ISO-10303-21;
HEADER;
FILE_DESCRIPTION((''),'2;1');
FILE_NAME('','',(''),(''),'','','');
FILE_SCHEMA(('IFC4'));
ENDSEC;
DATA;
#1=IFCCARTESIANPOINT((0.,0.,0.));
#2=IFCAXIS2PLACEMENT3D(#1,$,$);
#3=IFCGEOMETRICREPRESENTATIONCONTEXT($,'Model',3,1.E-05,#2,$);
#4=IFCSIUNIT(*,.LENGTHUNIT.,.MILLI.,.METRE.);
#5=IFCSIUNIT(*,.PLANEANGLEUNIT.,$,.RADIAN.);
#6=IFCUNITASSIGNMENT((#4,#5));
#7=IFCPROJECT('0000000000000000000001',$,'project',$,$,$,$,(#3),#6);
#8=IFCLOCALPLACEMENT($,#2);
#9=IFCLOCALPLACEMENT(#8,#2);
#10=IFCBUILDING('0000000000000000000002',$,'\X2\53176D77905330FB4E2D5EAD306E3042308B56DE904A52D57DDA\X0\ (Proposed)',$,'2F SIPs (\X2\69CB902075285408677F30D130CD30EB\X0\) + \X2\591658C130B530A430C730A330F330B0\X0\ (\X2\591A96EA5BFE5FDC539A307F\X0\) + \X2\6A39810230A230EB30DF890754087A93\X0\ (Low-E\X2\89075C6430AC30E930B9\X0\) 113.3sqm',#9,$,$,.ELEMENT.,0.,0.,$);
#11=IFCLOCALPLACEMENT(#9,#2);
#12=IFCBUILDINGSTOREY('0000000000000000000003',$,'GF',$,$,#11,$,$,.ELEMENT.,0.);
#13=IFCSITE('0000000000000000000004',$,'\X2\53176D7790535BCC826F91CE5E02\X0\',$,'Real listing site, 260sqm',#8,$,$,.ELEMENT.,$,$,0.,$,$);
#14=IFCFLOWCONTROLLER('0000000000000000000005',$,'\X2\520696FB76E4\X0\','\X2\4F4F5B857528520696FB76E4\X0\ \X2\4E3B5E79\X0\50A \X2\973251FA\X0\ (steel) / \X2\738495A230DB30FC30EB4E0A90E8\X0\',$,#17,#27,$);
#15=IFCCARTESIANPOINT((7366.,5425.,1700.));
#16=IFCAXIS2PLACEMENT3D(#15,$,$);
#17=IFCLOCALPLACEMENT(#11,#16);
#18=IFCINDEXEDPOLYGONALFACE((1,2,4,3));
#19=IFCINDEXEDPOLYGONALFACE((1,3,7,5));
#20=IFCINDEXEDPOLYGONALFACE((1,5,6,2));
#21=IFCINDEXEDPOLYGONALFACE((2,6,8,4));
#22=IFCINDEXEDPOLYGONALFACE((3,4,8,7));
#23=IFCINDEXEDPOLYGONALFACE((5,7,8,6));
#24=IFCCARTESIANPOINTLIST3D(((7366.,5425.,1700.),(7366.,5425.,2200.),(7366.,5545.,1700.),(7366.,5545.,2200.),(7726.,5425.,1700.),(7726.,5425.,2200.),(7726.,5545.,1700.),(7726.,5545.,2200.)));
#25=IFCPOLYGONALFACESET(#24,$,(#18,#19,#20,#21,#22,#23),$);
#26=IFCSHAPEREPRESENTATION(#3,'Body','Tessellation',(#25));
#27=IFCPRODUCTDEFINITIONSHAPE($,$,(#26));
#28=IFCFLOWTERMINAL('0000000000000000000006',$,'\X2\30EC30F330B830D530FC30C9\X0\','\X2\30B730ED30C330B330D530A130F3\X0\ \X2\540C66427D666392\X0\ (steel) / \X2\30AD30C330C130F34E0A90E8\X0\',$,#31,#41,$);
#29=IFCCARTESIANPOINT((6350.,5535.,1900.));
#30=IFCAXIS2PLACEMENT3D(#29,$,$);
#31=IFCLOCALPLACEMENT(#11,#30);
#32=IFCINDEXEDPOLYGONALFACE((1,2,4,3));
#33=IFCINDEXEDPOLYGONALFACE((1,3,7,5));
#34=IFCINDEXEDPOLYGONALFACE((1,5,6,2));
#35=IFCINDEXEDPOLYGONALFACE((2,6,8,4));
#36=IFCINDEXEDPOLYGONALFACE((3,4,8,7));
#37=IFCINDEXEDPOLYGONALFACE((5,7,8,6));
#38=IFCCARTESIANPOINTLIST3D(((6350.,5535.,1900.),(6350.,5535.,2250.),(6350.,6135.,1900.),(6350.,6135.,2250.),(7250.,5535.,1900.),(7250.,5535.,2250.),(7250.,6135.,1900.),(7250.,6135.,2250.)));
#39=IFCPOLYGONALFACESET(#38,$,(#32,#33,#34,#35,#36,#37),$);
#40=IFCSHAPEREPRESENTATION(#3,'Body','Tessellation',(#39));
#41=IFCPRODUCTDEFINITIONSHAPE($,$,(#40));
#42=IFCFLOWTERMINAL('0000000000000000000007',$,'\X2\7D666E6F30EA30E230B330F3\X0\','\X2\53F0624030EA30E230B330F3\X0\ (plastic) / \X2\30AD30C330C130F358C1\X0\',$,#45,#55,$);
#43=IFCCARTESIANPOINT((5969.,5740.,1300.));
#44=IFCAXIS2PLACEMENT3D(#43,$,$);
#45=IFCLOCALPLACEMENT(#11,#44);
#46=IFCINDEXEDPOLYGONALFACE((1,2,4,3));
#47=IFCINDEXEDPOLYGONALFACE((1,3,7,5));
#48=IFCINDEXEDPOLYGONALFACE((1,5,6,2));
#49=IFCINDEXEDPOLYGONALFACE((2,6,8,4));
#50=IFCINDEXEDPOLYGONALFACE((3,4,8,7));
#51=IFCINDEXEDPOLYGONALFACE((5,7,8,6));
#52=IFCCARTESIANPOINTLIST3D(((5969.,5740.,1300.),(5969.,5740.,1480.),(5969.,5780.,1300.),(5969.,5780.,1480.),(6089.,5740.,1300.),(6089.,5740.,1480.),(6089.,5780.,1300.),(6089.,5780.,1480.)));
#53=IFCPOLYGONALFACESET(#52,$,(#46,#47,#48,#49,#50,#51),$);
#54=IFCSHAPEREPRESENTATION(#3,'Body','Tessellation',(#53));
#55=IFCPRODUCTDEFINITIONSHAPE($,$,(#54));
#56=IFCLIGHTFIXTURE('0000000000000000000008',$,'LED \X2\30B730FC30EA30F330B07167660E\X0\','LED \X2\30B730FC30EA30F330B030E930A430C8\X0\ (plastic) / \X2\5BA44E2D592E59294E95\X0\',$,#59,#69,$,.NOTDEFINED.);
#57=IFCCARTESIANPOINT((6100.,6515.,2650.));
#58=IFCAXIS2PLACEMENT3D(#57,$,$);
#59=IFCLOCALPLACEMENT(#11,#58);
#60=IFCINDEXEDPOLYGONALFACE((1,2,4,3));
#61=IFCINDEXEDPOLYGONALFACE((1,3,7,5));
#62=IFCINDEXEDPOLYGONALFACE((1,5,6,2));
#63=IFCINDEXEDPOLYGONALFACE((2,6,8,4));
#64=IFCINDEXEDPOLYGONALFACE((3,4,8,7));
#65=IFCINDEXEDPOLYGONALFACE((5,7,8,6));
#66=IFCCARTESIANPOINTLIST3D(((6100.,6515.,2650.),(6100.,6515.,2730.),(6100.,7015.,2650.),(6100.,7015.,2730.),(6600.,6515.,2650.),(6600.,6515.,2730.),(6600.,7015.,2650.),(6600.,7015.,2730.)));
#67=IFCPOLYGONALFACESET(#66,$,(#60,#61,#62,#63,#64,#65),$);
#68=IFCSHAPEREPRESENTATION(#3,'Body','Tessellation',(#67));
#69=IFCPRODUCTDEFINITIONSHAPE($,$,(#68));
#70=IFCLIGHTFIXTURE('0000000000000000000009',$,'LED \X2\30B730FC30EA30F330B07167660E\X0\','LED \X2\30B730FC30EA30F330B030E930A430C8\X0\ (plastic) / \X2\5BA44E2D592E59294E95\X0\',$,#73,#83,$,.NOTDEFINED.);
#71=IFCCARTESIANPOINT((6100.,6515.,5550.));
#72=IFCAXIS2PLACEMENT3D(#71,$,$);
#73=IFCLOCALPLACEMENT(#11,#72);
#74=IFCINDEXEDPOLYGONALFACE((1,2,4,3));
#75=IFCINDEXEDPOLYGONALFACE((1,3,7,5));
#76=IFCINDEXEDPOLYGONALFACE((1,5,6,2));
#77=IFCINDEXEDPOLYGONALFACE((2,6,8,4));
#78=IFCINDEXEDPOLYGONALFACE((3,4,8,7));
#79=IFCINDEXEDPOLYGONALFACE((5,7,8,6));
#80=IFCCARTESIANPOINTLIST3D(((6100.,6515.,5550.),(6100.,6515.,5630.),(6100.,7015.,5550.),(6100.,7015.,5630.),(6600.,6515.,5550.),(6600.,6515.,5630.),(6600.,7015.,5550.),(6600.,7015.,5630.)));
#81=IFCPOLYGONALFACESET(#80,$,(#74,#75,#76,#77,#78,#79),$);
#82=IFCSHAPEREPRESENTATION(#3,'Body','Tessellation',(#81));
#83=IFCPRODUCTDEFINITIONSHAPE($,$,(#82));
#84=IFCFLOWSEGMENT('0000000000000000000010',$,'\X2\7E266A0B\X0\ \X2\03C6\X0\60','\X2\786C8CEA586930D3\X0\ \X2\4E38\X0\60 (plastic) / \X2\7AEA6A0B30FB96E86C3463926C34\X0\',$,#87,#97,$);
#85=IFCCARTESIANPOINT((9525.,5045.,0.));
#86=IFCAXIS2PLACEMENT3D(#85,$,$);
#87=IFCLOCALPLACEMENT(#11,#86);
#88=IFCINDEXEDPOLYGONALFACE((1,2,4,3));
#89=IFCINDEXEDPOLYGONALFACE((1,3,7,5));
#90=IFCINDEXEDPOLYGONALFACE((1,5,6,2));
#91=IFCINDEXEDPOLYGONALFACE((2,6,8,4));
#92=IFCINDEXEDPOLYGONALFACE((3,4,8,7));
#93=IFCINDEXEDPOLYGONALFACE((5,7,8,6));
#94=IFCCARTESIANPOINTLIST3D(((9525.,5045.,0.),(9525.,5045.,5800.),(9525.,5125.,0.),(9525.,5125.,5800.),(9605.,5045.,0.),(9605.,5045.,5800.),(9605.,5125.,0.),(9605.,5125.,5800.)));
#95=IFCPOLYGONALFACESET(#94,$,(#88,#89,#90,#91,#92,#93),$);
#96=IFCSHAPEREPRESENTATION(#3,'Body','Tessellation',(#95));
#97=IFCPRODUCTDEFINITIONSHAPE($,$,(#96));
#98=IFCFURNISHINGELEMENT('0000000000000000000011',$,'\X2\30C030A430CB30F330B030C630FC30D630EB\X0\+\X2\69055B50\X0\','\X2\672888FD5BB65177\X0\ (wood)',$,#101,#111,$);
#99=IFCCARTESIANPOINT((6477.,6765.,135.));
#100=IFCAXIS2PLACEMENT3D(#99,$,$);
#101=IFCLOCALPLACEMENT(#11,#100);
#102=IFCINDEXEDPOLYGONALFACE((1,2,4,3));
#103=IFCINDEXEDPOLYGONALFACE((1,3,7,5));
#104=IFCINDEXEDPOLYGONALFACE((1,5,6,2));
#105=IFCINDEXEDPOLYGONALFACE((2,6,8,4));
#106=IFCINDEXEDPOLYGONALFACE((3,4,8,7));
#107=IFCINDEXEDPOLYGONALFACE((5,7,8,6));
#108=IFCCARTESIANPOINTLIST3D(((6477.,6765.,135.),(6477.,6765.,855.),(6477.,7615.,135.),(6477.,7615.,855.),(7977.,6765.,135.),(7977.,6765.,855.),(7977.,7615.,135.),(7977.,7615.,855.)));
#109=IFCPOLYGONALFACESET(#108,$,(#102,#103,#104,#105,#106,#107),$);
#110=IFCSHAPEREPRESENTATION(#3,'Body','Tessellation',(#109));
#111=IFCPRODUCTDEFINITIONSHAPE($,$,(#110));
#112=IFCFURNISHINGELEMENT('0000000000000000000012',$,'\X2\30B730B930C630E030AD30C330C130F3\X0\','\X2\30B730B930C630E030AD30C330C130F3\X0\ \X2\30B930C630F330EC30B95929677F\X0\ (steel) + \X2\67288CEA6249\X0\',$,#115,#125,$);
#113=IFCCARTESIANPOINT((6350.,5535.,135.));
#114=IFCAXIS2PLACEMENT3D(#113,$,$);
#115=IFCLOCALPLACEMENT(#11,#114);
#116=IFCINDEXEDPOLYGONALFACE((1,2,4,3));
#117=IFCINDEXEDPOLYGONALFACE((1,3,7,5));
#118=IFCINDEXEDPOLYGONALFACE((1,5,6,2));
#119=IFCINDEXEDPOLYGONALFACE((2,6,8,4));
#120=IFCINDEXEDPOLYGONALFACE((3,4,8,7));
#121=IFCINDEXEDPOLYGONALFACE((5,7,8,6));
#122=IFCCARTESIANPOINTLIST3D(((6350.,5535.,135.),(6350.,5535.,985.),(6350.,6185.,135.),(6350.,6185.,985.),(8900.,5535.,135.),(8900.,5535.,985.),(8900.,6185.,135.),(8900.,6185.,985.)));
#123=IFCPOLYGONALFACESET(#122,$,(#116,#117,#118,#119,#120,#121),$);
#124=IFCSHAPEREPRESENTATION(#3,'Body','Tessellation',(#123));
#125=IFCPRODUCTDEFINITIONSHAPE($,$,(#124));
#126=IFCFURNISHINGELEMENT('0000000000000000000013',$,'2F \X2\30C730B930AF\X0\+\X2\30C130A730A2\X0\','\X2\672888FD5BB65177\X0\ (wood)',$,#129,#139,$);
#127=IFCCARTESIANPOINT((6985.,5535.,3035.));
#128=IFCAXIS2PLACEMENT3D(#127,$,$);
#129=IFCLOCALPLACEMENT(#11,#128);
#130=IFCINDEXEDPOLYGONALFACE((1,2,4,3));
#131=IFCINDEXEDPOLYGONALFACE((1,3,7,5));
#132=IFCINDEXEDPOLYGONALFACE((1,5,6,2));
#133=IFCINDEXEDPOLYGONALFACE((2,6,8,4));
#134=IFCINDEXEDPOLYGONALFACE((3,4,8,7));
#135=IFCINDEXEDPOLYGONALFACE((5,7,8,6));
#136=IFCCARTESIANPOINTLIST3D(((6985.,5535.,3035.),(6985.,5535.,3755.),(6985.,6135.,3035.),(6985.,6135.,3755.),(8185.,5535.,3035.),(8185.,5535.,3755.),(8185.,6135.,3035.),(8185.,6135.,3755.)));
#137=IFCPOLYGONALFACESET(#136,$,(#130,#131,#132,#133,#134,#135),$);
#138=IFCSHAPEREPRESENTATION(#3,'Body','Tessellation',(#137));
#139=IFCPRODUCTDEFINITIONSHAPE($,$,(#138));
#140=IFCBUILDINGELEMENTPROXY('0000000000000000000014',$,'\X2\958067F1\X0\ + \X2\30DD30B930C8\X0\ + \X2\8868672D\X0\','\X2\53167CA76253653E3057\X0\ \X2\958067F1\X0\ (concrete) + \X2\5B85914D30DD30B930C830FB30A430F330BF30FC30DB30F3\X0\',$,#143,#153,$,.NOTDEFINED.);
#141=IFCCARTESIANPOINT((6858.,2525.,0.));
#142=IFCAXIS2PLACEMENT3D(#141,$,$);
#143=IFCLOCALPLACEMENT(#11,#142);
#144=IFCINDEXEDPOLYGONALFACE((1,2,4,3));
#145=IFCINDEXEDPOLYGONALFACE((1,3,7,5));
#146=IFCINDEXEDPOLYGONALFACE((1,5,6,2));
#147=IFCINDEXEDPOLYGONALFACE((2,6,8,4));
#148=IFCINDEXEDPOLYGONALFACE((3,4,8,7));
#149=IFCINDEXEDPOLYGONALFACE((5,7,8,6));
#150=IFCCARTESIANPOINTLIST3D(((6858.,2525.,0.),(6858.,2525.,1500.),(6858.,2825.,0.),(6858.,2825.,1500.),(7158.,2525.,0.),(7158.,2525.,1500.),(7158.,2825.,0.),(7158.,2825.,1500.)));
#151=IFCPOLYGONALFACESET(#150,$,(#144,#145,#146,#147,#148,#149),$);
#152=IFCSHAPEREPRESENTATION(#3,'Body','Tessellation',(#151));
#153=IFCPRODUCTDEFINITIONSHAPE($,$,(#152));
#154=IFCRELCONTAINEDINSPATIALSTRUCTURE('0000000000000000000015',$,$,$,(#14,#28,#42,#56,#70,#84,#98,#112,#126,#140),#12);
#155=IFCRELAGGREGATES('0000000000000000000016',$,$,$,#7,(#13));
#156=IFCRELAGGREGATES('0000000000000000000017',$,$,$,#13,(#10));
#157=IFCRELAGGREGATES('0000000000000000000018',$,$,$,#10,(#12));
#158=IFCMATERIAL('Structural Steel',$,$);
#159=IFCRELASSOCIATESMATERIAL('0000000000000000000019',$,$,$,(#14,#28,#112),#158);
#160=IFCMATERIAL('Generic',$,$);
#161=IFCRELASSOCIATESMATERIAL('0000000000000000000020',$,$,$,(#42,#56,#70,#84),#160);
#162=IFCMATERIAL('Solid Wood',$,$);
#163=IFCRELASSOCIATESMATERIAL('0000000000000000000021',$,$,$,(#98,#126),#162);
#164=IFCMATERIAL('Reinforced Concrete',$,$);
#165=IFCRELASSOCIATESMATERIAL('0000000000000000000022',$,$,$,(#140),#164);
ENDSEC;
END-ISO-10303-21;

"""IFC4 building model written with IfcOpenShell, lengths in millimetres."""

from ifc_helpers import new_model, si_unit, frame, frame_2d, origin, place, context, project, spatial, rectangle, extrude, material, element, save


model = new_model("IFC4")

# Units and contexts
model_context = context("Model", 3, precision=1e-05, world=origin())
ifc_project = project(units=[si_unit("LENGTHUNIT", "METRE", prefix="MILLI"), si_unit("PLANEANGLEUNIT", "RADIAN")], contexts=[model_context])

# Site, building, storey
site_placement = place(None, origin())
site = spatial("IfcSite", under=ifc_project, at=site_placement, Name="北海道富良野市", ObjectType="Real listing site, 260sqm", CompositionType="ELEMENT", RefElevation=0.0)
building_placement = place(site_placement, origin())
building = spatial("IfcBuilding", under=site, at=building_placement, Name="北海道・中庭のある回遊動線 (Proposed)", ObjectType="2F SIPs (構造用合板パネル) + 外壁サイディング (多雪対応厚み) + 樹脂アルミ複合窓 (Low-E複層ガラス) 113.3sqm", CompositionType="ELEMENT", ElevationOfRefHeight=0.0, ElevationOfTerrain=0.0)
storey_placement = place(building_placement, origin())
storey = spatial("IfcBuildingStorey", under=building, at=storey_placement, Name="GF", CompositionType="ELEMENT", Elevation=0.0)

# Shared definitions
ifc_material_1 = material(Name="Solid Wood")

# Shared definitions
ifc_material_2 = material(Name="Reinforced Concrete")

# Flow controller
ifc_material_3 = material(Name="Structural Steel")
flow_controller_placement = place(storey_placement, frame((7366.0, 5425.0, 1700.0)))
element("IfcFlowController", 1, at=flow_controller_placement, inside=storey, material=ifc_material_3, Name="分電盤", Description="住宅用分電盤 主幹50A 露出 (steel) / 玄関ホール上部", context=model_context, shape_type="SweptSolid", body=[
    extrude(rectangle(XDim=360.0, YDim=120.0, at=frame_2d((180.0, 60.0))), frame((7366.0, 5425.0, 1700.0)), (0.0, 0.0, 1.0), 500.0),
])

# Flow terminals
flow_terminal_1_placement = place(storey_placement, frame((6350.0, 5535.0, 1900.0)))
element("IfcFlowTerminal", 2, at=flow_terminal_1_placement, inside=storey, material=ifc_material_3, Name="レンジフード", Description="シロッコファン 同時給排 (steel) / キッチン上部", context=model_context, shape_type="SweptSolid", body=[
    extrude(rectangle(XDim=900.0, YDim=600.0, at=frame_2d((450.0, 300.0))), frame((6350.0, 5535.0, 1900.0)), (0.0, 0.0, 1.0), 350.0),
])
ifc_material_4 = material(Name="Generic")
flow_terminal_2_placement = place(storey_placement, frame((5969.0, 5740.0, 1300.0)))
element("IfcFlowTerminal", 3, at=flow_terminal_2_placement, inside=storey, material=ifc_material_4, Name="給湯リモコン", Description="台所リモコン (plastic) / キッチン壁", context=model_context, shape_type="SweptSolid", body=[
    extrude(rectangle(XDim=120.0, YDim=40.0, at=frame_2d((60.0, 20.0))), frame((5969.0, 5740.0, 1300.0)), (0.0, 0.0, 1.0), 180.0),
])

# Light fixtures
light_fixture_1_placement = place(storey_placement, frame((6100.0, 6515.0, 2650.0)))
element("IfcLightFixture", 4, at=light_fixture_1_placement, inside=storey, material=ifc_material_4, Name="LED シーリング照明", Description="LED シーリングライト (plastic) / 室中央天井", PredefinedType="NOTDEFINED", context=model_context, shape_type="SweptSolid", body=[
    extrude(rectangle(XDim=500.0, YDim=500.0, at=frame_2d((250.0, 250.0))), frame((6100.0, 6515.0, 2650.0)), (0.0, 0.0, 1.0), 80.0),
])
light_fixture_2_placement = place(storey_placement, frame((6100.0, 6515.0, 5550.0)))
element("IfcLightFixture", 5, at=light_fixture_2_placement, inside=storey, material=ifc_material_4, Name="LED シーリング照明", Description="LED シーリングライト (plastic) / 室中央天井", PredefinedType="NOTDEFINED", context=model_context, shape_type="SweptSolid", body=[
    extrude(rectangle(XDim=500.0, YDim=500.0, at=frame_2d((250.0, 250.0))), frame((6100.0, 6515.0, 5550.0)), (0.0, 0.0, 1.0), 80.0),
])

# Flow segment
flow_segment_placement = place(storey_placement, frame((9525.0, 5045.0, 0.0)))
element("IfcFlowSegment", 6, at=flow_segment_placement, inside=storey, material=ifc_material_4, Name="縦樋 φ60", Description="硬質塩ビ 丸60 (plastic) / 竪樋・雨水排水", context=model_context, shape_type="SweptSolid", body=[
    extrude(rectangle(XDim=80.0, YDim=80.0, at=frame_2d((40.0, 40.0))), frame((9525.0, 5045.0, 0.0)), (0.0, 0.0, 1.0), 5800.0),
])

# Furnishing elements
furnishing_1_placement = place(storey_placement, frame((6477.0, 6765.0, 135.0)))
element("IfcFurnishingElement", 7, at=furnishing_1_placement, inside=storey, material=ifc_material_1, Name="ダイニングテーブル+椅子", Description="木製家具 (wood)", context=model_context, shape_type="SweptSolid", body=[
    extrude(rectangle(XDim=1500.0, YDim=850.0, at=frame_2d((750.0, 425.0))), frame((6477.0, 6765.0, 135.0)), (0.0, 0.0, 1.0), 720.0),
])
furnishing_2_placement = place(storey_placement, frame((6350.0, 5535.0, 135.0)))
element("IfcFurnishingElement", 8, at=furnishing_2_placement, inside=storey, material=ifc_material_3, Name="システムキッチン", Description="システムキッチン ステンレス天板 (steel) + 木質扉", context=model_context, shape_type="SweptSolid", body=[
    extrude(rectangle(XDim=2550.0, YDim=650.0, at=frame_2d((1275.0, 325.0))), frame((6350.0, 5535.0, 135.0)), (0.0, 0.0, 1.0), 850.0),
])
furnishing_3_placement = place(storey_placement, frame((6985.0, 5535.0, 3035.0)))
element("IfcFurnishingElement", 9, at=furnishing_3_placement, inside=storey, material=ifc_material_1, Name="2F デスク+チェア", Description="木製家具 (wood)", context=model_context, shape_type="SweptSolid", body=[
    extrude(rectangle(XDim=1200.0, YDim=600.0, at=frame_2d((600.0, 300.0))), frame((6985.0, 5535.0, 3035.0)), (0.0, 0.0, 1.0), 720.0),
])

# Building element proxy
proxy_placement = place(storey_placement, frame((6858.0, 2525.0, 0.0)))
element("IfcBuildingElementProxy", 10, at=proxy_placement, inside=storey, material=ifc_material_2, Name="門柱 + ポスト + 表札", Description="化粧打放し 門柱 (concrete) + 宅配ポスト・インターホン", PredefinedType="NOTDEFINED", context=model_context, shape_type="SweptSolid", body=[
    extrude(rectangle(XDim=300.0, YDim=300.0, at=frame_2d((150.0, 150.0))), frame((6858.0, 2525.0, 0.0)), (0.0, 0.0, 1.0), 1500.0),
])

save(model, "model.ifc")
